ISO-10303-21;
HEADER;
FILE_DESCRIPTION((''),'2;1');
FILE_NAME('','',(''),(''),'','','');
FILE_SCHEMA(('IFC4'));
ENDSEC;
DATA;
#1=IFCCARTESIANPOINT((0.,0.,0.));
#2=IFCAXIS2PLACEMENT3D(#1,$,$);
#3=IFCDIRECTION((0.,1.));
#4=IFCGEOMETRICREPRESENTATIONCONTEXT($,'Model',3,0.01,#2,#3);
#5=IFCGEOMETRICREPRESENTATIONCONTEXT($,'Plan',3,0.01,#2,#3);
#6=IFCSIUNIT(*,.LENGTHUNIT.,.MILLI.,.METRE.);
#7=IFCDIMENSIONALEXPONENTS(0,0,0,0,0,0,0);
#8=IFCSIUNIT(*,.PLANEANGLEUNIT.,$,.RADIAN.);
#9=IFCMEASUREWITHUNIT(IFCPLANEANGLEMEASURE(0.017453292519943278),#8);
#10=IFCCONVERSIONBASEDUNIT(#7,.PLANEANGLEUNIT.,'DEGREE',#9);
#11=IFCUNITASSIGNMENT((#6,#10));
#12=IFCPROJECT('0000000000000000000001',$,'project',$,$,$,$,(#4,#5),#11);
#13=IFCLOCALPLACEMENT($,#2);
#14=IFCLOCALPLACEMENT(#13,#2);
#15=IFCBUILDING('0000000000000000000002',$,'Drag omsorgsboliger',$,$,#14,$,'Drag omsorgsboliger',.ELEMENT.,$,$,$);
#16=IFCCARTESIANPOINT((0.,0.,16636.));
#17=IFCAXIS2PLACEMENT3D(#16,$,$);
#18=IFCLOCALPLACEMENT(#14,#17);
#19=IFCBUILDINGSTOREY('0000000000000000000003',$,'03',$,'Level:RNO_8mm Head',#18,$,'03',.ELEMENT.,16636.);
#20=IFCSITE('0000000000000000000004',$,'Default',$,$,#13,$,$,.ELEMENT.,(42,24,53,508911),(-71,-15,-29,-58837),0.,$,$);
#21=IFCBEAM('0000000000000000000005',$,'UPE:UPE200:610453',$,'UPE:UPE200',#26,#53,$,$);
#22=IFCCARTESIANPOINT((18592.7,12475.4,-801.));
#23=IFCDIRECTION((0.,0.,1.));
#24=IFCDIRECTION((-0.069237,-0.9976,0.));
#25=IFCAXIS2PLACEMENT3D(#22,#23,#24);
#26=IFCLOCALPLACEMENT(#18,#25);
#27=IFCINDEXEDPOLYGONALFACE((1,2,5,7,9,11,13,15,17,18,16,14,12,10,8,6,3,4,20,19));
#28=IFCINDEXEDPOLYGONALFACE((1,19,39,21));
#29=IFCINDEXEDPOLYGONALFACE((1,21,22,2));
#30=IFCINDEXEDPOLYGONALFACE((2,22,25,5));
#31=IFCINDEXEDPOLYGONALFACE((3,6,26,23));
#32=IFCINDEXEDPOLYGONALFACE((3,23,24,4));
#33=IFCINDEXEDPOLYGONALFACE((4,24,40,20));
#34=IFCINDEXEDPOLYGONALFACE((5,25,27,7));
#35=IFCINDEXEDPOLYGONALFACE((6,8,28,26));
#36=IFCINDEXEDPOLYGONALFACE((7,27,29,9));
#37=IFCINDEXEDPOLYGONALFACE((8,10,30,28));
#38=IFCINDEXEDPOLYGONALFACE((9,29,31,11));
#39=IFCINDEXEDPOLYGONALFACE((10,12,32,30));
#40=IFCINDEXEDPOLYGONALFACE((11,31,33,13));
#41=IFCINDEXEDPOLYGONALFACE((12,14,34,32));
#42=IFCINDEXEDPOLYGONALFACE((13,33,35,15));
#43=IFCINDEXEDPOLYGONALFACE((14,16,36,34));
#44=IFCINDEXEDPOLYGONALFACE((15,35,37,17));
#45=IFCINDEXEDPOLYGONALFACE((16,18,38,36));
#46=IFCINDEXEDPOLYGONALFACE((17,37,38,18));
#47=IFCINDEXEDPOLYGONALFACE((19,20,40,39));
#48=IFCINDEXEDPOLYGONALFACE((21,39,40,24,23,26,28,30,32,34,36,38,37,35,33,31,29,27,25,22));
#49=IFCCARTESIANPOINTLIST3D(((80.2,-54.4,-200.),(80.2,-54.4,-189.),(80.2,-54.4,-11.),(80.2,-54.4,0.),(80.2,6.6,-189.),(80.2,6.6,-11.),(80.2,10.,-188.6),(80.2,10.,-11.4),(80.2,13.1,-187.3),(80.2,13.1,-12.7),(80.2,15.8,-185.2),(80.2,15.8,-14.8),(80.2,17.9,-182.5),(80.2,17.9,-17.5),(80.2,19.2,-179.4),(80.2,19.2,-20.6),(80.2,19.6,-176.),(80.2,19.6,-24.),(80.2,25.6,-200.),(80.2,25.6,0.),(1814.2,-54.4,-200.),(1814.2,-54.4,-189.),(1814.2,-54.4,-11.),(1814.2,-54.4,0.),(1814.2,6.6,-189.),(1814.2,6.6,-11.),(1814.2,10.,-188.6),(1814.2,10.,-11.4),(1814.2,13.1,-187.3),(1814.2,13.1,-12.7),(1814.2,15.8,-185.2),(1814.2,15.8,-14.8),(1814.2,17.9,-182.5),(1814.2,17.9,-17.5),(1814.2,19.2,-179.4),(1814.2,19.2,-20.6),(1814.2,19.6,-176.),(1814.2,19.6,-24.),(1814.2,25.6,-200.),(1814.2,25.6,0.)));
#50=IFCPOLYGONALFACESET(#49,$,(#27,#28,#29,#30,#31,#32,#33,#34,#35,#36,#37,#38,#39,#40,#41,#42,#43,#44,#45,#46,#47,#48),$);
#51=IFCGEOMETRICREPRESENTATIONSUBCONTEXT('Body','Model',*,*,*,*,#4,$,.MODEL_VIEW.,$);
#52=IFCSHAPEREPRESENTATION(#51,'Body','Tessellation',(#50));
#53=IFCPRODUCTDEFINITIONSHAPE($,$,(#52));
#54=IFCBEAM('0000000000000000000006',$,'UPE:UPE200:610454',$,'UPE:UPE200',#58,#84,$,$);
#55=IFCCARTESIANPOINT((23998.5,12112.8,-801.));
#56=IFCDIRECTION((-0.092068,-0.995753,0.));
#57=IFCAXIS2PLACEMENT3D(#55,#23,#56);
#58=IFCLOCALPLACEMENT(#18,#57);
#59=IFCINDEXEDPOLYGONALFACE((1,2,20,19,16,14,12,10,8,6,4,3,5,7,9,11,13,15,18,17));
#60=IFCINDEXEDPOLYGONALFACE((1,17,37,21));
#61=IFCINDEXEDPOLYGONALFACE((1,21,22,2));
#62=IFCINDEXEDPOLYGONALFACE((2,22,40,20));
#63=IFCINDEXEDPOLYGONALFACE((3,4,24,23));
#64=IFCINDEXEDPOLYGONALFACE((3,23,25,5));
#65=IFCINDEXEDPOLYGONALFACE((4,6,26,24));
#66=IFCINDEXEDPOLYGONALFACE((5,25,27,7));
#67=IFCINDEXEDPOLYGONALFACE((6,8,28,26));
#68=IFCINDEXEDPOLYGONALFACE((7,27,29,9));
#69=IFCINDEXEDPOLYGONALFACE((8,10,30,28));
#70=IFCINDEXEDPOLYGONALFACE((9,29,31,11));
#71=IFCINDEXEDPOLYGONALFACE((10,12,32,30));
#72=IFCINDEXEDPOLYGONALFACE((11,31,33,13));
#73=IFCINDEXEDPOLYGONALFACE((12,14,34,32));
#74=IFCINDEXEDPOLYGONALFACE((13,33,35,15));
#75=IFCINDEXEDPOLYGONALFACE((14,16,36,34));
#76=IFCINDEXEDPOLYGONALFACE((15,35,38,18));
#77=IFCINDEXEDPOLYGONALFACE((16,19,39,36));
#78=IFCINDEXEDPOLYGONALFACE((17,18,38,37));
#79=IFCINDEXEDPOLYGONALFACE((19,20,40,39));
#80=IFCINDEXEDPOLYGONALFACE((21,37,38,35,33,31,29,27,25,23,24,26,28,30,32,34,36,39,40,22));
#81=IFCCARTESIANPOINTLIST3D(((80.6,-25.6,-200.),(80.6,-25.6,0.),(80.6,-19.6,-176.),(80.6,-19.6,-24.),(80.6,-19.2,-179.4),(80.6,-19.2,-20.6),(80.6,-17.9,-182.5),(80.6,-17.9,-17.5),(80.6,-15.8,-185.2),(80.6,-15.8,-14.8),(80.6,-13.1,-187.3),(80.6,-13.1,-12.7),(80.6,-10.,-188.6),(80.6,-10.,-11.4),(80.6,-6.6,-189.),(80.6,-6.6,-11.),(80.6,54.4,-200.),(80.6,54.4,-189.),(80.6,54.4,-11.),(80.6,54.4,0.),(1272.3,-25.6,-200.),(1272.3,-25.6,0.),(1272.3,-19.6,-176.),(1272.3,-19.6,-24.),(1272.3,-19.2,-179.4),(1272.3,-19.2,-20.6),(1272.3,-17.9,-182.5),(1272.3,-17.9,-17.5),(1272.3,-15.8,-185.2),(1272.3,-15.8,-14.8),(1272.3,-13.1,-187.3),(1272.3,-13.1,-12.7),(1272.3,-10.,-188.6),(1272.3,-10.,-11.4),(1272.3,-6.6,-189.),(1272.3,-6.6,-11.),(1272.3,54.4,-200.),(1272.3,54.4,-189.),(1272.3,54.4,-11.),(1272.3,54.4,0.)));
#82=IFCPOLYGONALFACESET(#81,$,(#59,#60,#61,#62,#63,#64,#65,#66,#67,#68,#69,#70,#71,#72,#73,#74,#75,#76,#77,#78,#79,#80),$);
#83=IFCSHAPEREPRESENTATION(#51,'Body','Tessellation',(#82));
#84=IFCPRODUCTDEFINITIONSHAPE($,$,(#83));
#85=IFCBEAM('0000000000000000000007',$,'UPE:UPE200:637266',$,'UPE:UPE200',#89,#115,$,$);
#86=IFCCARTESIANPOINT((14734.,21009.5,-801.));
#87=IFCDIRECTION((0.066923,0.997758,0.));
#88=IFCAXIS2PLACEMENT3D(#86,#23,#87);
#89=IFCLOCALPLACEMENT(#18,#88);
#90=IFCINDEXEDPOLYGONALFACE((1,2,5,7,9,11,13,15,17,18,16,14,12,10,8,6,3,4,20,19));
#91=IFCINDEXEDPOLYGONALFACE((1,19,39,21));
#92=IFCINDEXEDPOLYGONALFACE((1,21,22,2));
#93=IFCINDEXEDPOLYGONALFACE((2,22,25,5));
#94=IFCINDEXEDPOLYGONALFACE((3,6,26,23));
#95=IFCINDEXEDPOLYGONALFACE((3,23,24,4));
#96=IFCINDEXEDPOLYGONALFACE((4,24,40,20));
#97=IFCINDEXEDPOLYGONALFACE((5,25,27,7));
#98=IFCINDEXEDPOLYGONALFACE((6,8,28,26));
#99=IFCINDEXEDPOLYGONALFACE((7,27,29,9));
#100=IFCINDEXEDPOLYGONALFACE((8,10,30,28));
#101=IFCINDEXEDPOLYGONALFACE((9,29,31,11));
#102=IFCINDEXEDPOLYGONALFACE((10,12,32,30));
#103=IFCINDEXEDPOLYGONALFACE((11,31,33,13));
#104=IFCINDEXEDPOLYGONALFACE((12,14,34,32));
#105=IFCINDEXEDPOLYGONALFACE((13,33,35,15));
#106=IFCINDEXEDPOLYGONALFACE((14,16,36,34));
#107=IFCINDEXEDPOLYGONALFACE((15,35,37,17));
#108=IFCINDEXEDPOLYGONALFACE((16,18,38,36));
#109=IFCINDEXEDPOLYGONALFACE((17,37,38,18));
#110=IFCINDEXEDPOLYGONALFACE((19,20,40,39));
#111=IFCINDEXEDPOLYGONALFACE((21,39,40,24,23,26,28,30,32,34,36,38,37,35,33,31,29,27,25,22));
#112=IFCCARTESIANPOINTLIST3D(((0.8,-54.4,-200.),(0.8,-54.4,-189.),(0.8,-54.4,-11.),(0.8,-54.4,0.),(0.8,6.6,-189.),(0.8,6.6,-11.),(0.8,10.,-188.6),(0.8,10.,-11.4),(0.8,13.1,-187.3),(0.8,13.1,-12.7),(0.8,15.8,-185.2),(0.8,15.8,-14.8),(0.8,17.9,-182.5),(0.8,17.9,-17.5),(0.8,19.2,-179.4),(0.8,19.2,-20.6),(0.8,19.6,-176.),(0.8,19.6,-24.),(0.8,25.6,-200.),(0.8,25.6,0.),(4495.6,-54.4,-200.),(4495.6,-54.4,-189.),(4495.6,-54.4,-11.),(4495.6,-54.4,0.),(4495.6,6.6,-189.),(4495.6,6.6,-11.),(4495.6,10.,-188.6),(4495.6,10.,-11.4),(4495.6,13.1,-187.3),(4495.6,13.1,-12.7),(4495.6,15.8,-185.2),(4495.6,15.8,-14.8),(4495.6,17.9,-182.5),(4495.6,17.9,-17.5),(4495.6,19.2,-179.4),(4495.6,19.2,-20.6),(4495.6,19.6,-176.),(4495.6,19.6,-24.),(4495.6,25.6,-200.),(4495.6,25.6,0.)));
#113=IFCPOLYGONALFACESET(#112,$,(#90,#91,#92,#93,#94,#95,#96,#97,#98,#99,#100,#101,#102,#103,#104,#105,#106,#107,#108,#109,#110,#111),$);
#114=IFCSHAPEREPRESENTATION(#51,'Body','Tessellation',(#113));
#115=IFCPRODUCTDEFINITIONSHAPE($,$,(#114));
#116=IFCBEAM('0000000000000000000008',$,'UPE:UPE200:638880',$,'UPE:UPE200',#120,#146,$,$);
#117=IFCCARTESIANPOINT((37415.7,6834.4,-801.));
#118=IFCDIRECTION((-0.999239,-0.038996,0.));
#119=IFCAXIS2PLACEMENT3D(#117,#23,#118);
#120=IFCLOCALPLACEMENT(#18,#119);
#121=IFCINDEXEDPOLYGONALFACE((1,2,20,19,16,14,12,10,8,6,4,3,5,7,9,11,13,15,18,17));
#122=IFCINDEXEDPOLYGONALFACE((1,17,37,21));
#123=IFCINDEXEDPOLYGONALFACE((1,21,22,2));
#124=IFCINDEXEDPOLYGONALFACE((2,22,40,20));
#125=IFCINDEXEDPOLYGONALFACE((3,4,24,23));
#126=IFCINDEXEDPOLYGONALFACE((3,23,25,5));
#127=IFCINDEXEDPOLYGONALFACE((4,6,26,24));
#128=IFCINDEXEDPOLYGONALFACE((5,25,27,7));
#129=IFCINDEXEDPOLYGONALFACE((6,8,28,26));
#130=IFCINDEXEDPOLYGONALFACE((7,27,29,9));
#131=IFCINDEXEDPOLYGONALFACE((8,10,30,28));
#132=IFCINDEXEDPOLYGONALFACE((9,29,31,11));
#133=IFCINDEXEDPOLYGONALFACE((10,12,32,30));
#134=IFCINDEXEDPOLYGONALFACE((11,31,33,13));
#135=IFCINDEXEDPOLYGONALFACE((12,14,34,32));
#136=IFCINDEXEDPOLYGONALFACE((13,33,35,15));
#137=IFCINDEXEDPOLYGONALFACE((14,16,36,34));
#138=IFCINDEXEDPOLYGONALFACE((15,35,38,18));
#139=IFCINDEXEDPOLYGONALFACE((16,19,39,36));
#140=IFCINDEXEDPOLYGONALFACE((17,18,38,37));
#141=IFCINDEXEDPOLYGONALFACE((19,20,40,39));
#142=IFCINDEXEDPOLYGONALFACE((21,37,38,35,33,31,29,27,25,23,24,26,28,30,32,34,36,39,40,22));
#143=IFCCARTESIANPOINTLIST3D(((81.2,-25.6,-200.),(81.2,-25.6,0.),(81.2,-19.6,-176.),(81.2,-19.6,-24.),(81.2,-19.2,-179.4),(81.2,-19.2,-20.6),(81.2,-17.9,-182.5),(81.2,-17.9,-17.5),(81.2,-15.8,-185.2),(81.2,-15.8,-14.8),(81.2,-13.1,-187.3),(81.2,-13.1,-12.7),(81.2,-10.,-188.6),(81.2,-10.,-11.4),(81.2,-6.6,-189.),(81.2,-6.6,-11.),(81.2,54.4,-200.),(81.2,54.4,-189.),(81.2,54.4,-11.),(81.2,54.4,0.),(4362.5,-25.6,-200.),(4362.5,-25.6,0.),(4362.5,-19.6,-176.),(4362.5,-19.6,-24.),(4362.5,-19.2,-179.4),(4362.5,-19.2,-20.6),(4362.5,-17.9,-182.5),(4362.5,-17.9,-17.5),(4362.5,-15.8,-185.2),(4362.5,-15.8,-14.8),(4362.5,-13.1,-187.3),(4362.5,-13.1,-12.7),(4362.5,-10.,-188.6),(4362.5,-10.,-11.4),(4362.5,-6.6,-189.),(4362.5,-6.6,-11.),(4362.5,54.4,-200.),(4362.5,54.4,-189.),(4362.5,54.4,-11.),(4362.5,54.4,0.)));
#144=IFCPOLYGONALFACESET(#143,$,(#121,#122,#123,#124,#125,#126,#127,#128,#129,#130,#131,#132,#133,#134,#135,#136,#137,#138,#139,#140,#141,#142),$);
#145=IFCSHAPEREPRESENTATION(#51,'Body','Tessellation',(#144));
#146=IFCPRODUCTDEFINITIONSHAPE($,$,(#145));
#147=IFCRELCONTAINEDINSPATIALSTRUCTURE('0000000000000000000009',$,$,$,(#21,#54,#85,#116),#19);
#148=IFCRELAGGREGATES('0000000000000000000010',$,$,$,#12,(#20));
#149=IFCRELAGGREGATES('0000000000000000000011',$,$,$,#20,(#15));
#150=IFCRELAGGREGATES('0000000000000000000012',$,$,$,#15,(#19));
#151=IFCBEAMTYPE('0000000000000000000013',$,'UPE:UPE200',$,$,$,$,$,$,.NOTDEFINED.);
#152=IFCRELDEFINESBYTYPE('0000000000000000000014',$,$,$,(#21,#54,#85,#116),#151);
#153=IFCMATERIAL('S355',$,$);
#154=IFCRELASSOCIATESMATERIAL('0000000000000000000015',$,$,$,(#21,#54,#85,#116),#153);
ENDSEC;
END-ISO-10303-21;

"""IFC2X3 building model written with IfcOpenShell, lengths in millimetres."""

from ifc_helpers import new_model, entity, si_unit, converted_unit, direction, frame, frame_2d, origin, place, context, subcontext, project, spatial, polyline, circle_curve, parameter, trimmed, segment, composite_curve, outline, extrude, material, type_object, element, save


model = new_model("IFC2X3")

# Units and contexts
model_context = context("Model", 3, precision=0.01, world=origin(), true_north=direction((0.0, 1.0)))
plan_context = context("Plan", 3, precision=0.01, world=origin(), true_north=direction((0.0, 1.0)))
body_context = subcontext(model_context, "Body", "Model", "MODEL_VIEW")
ifc_project = project(units=[si_unit("LENGTHUNIT", "METRE", prefix="MILLI"), converted_unit("PLANEANGLEUNIT", "DEGREE", entity("IfcPlaneAngleMeasure", 0.017453292519943278), si_unit("PLANEANGLEUNIT", "RADIAN"), dimensions=[0, 0, 0, 0, 0, 0, 0])], contexts=[model_context, plan_context])

# Site, building, storey
site_placement = place(None, origin())
site = spatial("IfcSite", under=ifc_project, at=site_placement, Name="Default", CompositionType="ELEMENT", RefLatitude=(42, 24, 53, 508911), RefLongitude=(-71, -15, -29, -58837), RefElevation=0.0)
building_placement = place(site_placement, origin())
building = spatial("IfcBuilding", under=site, at=building_placement, Name="Drag omsorgsboliger", LongName="Drag omsorgsboliger", CompositionType="ELEMENT")
storey_placement = place(building_placement, frame((0.0, 0.0, 16636.0)))
storey = spatial("IfcBuildingStorey", under=building, at=storey_placement, Name="03", ObjectType="Level:RNO_8mm Head", LongName="03", CompositionType="ELEMENT", Elevation=16636.0)

# Beams
ifc_material = material(Name="S355")
beam_type_1 = type_object("IfcBeamType", Name="UPE:UPE200", PredefinedType="NOTDEFINED")
beam_1_placement = place(storey_placement, frame((18592.7, 12475.4, -801.0), z_axis=(0.0, 0.0, 1.0), x_axis=(-0.069237, -0.9976, 0.0)))
element("IfcBeam", 1, at=beam_1_placement, inside=storey, type_object=beam_type_1, material=ifc_material, Name="UPE:UPE200:610453", ObjectType="UPE:UPE200", context=body_context, shape_type="SweptSolid", body=[
    extrude(outline(composite_curve([segment(polyline([(-100.0, -43.0), (-89.0, -43.0)]), True, "CONTINUOUS"), segment(polyline([(-89.0, -43.0), (-89.0, 18.0)]), True, "CONTINUOUS"), segment(trimmed(circle_curve(frame_2d((-76.0, 18.0), x_axis=(-1.0, 0.0)), 13.0), [parameter(270.0)], [parameter(0.0)], True, "PARAMETER"), False, "CONTINUOUS"), segment(polyline([(-76.0, 31.0), (76.0, 31.0)]), True, "CONTINUOUS"), segment(trimmed(circle_curve(frame_2d((76.0, 18.0), x_axis=(0.0, 1.0)), 13.0), [parameter(270.0)], [parameter(0.0)], True, "PARAMETER"), False, "CONTINUOUS"), segment(polyline([(89.0, 18.0), (89.0, -43.0)]), True, "CONTINUOUS"), segment(polyline([(89.0, -43.0), (100.0, -43.0)]), True, "CONTINUOUS"), segment(polyline([(100.0, -43.0), (100.0, 37.0)]), True, "CONTINUOUS"), segment(polyline([(100.0, 37.0), (-100.0, 37.0)]), True, "CONTINUOUS"), segment(polyline([(-100.0, 37.0), (-100.0, -43.0)]), True, "CONTINUOUS")], self_intersect=False)), frame((80.2, -11.4, -100.0), z_axis=(1.0, 0.0, 0.0), x_axis=(0.0, 0.0, -1.0)), (0.0, 0.0, 1.0), 1734.0),
])
beam_2_placement = place(storey_placement, frame((23998.5, 12112.8, -801.0), z_axis=(0.0, 0.0, 1.0), x_axis=(-0.092068, -0.995753, 0.0)))
element("IfcBeam", 2, at=beam_2_placement, inside=storey, type_object=beam_type_1, material=ifc_material, Name="UPE:UPE200:610454", ObjectType="UPE:UPE200", context=body_context, shape_type="SweptSolid", body=[
    extrude(outline(composite_curve([segment(polyline([(-100.0, -37.0), (100.0, -37.0)]), True, "CONTINUOUS"), segment(polyline([(100.0, -37.0), (100.0, 43.0)]), True, "CONTINUOUS"), segment(polyline([(100.0, 43.0), (89.0, 43.0)]), True, "CONTINUOUS"), segment(polyline([(89.0, 43.0), (89.0, -18.0)]), True, "CONTINUOUS"), segment(trimmed(circle_curve(frame_2d((76.0, -18.0), x_axis=(1.0, 0.0)), 13.0), [parameter(270.0)], [parameter(0.0)], True, "PARAMETER"), False, "CONTINUOUS"), segment(polyline([(76.0, -31.0), (-76.0, -31.0)]), True, "CONTINUOUS"), segment(trimmed(circle_curve(frame_2d((-76.0, -18.0), x_axis=(0.0, -1.0)), 13.0), [parameter(270.0)], [parameter(0.0)], True, "PARAMETER"), False, "CONTINUOUS"), segment(polyline([(-89.0, -18.0), (-89.0, 43.0)]), True, "CONTINUOUS"), segment(polyline([(-89.0, 43.0), (-100.0, 43.0)]), True, "CONTINUOUS"), segment(polyline([(-100.0, 43.0), (-100.0, -37.0)]), True, "CONTINUOUS")], self_intersect=False)), frame((80.6, 11.4, -100.0), z_axis=(1.0, 0.0, 0.0), x_axis=(0.0, 0.0, -1.0)), (0.0, 0.0, 1.0), 1191.7),
])
beam_3_placement = place(storey_placement, frame((14734.0, 21009.5, -801.0), z_axis=(0.0, 0.0, 1.0), x_axis=(0.066923, 0.997758, 0.0)))
element("IfcBeam", 3, at=beam_3_placement, inside=storey, type_object=beam_type_1, material=ifc_material, Name="UPE:UPE200:637266", ObjectType="UPE:UPE200", context=body_context, shape_type="SweptSolid", body=[
    extrude(outline(composite_curve([segment(polyline([(-100.0, -43.0), (-89.0, -43.0)]), True, "CONTINUOUS"), segment(polyline([(-89.0, -43.0), (-89.0, 18.0)]), True, "CONTINUOUS"), segment(trimmed(circle_curve(frame_2d((-76.0, 18.0), x_axis=(-1.0, 0.0)), 13.0), [parameter(270.0)], [parameter(0.0)], True, "PARAMETER"), False, "CONTINUOUS"), segment(polyline([(-76.0, 31.0), (76.0, 31.0)]), True, "CONTINUOUS"), segment(trimmed(circle_curve(frame_2d((76.0, 18.0), x_axis=(0.0, 1.0)), 13.0), [parameter(270.0)], [parameter(0.0)], True, "PARAMETER"), False, "CONTINUOUS"), segment(polyline([(89.0, 18.0), (89.0, -43.0)]), True, "CONTINUOUS"), segment(polyline([(89.0, -43.0), (100.0, -43.0)]), True, "CONTINUOUS"), segment(polyline([(100.0, -43.0), (100.0, 37.0)]), True, "CONTINUOUS"), segment(polyline([(100.0, 37.0), (-100.0, 37.0)]), True, "CONTINUOUS"), segment(polyline([(-100.0, 37.0), (-100.0, -43.0)]), True, "CONTINUOUS")], self_intersect=False)), frame((0.8, -11.4, -100.0), z_axis=(1.0, 0.0, 0.0), x_axis=(0.0, 0.0, -1.0)), (0.0, 0.0, 1.0), 4494.8),
])
beam_4_placement = place(storey_placement, frame((37415.7, 6834.4, -801.0), z_axis=(0.0, 0.0, 1.0), x_axis=(-0.999239, -0.038996, 0.0)))
element("IfcBeam", 4, at=beam_4_placement, inside=storey, type_object=beam_type_1, material=ifc_material, Name="UPE:UPE200:638880", ObjectType="UPE:UPE200", context=body_context, shape_type="SweptSolid", body=[
    extrude(outline(composite_curve([segment(polyline([(-100.0, -37.0), (100.0, -37.0)]), True, "CONTINUOUS"), segment(polyline([(100.0, -37.0), (100.0, 43.0)]), True, "CONTINUOUS"), segment(polyline([(100.0, 43.0), (89.0, 43.0)]), True, "CONTINUOUS"), segment(polyline([(89.0, 43.0), (89.0, -18.0)]), True, "CONTINUOUS"), segment(trimmed(circle_curve(frame_2d((76.0, -18.0), x_axis=(1.0, 0.0)), 13.0), [parameter(270.0)], [parameter(0.0)], True, "PARAMETER"), False, "CONTINUOUS"), segment(polyline([(76.0, -31.0), (-76.0, -31.0)]), True, "CONTINUOUS"), segment(trimmed(circle_curve(frame_2d((-76.0, -18.0), x_axis=(0.0, -1.0)), 13.0), [parameter(270.0)], [parameter(0.0)], True, "PARAMETER"), False, "CONTINUOUS"), segment(polyline([(-89.0, -18.0), (-89.0, 43.0)]), True, "CONTINUOUS"), segment(polyline([(-89.0, 43.0), (-100.0, 43.0)]), True, "CONTINUOUS"), segment(polyline([(-100.0, 43.0), (-100.0, -37.0)]), True, "CONTINUOUS")], self_intersect=False)), frame((81.2, 11.4, -100.0), z_axis=(1.0, 0.0, 0.0), x_axis=(0.0, 0.0, -1.0)), (0.0, 0.0, 1.0), 4281.3),
])

save(model, "model.ifc")
